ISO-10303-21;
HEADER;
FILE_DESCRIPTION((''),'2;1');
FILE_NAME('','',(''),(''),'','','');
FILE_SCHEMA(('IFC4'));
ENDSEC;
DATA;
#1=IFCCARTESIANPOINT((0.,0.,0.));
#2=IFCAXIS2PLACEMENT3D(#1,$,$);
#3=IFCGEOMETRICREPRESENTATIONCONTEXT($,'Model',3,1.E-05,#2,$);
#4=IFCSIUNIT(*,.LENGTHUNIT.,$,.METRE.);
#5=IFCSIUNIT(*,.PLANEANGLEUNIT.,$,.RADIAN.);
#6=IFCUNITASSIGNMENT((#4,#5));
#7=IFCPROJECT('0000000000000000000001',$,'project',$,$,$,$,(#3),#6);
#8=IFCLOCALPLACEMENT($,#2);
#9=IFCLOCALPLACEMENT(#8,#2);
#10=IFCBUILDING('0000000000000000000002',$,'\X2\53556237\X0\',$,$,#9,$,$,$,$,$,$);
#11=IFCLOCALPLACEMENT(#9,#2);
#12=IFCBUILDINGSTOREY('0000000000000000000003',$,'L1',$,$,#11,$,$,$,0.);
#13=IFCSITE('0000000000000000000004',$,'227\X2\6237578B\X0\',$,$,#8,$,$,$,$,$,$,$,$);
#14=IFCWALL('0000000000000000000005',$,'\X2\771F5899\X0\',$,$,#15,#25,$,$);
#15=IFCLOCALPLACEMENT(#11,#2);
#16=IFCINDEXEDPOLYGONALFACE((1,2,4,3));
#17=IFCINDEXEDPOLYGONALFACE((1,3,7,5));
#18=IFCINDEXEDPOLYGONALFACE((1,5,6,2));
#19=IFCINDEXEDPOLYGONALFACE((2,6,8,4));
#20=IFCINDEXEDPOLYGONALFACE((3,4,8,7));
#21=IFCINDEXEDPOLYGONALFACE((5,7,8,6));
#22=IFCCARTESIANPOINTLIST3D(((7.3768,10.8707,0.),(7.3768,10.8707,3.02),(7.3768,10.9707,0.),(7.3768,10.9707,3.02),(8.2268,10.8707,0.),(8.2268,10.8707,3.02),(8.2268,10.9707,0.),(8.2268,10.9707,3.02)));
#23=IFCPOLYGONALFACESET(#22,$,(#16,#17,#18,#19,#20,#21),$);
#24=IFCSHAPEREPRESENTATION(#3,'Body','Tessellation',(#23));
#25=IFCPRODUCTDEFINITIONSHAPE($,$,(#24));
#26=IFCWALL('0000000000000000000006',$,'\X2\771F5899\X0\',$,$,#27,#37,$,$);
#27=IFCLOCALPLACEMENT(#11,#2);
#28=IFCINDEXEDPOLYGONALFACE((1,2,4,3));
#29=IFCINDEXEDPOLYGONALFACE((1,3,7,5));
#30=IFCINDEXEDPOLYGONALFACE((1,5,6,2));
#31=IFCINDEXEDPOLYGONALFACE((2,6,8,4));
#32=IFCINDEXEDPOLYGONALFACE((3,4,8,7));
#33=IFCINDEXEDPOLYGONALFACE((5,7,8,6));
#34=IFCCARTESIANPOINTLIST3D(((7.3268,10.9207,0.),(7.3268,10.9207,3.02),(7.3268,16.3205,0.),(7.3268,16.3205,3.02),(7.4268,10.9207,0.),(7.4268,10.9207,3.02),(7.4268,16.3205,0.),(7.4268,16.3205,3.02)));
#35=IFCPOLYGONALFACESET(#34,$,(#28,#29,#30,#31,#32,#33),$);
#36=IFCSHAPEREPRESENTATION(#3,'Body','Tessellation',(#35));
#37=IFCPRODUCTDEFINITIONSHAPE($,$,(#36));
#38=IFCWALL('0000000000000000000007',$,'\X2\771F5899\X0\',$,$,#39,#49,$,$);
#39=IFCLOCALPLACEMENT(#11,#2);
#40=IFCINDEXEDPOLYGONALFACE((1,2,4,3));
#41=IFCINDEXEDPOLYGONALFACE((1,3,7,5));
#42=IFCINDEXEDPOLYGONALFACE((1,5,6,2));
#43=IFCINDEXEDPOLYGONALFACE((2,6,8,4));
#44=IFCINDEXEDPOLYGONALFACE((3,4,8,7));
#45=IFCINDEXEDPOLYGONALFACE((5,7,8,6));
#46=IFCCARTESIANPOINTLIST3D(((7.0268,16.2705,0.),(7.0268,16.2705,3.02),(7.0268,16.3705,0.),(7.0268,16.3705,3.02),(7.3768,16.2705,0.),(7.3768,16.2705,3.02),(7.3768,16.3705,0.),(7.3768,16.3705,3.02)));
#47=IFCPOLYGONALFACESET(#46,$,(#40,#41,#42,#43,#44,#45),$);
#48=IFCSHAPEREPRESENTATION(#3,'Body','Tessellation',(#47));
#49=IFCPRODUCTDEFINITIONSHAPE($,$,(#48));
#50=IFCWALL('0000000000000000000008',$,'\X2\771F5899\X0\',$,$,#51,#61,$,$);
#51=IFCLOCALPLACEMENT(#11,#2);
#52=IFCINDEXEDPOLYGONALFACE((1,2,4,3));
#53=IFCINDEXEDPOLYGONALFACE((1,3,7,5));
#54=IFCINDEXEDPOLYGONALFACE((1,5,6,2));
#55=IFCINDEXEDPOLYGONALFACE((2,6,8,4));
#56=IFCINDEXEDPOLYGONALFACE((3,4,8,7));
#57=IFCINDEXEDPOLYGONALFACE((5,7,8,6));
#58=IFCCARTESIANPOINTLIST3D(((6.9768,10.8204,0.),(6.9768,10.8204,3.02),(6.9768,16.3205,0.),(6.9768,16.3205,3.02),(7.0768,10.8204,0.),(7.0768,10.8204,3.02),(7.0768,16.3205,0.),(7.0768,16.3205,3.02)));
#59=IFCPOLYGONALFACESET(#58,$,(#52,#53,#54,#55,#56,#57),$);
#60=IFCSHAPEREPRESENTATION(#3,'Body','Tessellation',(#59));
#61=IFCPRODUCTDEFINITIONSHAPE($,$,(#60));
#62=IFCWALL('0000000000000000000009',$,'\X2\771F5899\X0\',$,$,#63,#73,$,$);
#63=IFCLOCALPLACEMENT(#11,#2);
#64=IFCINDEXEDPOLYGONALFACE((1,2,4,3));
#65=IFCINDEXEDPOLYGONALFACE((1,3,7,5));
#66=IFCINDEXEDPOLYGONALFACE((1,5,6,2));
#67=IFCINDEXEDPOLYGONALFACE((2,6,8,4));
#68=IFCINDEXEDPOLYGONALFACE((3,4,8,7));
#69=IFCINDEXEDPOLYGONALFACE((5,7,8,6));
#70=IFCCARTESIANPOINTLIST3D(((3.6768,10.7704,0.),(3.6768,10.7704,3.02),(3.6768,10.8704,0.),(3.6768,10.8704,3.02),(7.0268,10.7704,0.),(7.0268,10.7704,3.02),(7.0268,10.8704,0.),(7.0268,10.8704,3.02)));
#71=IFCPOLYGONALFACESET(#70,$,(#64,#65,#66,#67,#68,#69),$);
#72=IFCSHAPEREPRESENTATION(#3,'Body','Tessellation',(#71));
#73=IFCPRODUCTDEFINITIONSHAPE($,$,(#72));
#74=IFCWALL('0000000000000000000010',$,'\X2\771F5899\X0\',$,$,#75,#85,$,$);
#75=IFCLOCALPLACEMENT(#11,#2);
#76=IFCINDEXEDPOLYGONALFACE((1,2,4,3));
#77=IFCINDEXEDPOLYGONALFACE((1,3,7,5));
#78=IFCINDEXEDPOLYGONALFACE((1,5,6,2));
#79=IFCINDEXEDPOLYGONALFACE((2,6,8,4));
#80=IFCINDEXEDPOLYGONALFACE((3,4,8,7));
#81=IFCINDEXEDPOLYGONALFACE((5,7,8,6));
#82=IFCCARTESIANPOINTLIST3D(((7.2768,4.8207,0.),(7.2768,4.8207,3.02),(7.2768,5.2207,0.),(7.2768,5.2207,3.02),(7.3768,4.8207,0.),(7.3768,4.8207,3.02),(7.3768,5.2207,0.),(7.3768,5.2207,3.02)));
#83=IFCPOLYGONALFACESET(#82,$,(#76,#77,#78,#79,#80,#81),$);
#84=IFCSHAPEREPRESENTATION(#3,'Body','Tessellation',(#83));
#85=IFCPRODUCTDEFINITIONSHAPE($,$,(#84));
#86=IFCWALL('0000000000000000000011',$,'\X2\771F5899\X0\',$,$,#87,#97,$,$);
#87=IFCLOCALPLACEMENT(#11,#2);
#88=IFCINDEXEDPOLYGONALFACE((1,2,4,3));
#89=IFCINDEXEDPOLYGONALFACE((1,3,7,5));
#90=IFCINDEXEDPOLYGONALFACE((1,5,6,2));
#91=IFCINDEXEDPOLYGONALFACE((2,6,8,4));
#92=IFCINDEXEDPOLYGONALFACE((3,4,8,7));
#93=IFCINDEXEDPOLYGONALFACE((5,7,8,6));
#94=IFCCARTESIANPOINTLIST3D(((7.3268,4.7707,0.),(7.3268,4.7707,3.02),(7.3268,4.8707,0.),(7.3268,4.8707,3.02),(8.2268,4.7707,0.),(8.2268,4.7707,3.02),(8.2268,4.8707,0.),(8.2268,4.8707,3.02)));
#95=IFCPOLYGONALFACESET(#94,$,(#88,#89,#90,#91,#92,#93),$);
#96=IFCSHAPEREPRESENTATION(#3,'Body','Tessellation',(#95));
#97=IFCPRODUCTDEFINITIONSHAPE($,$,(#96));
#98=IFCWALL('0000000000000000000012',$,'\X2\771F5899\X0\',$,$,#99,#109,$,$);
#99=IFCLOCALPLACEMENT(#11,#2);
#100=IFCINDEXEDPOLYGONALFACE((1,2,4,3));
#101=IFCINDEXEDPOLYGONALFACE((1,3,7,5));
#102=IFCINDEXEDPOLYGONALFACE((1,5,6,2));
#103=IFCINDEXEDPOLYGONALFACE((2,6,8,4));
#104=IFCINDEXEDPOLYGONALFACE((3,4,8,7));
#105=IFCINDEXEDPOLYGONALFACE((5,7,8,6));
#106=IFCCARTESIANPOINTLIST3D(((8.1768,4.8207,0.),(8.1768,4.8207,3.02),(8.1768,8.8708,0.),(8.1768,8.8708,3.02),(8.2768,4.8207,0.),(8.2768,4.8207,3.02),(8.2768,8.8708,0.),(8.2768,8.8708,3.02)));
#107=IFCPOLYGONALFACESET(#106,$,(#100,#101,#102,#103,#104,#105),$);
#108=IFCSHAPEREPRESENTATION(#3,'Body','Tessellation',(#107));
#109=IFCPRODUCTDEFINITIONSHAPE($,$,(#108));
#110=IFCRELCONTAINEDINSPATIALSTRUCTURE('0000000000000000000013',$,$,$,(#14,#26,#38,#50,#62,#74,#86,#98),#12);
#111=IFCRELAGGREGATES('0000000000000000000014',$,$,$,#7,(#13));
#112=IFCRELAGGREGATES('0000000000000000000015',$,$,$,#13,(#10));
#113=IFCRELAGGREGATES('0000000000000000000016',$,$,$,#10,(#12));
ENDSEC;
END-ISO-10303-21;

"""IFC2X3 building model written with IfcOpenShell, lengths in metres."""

from ifc_helpers import new_model, si_unit, origin, place, context, project, spatial, polyline, outline, extrude, element, save


model = new_model("IFC2X3")

# Units and contexts
model_context = context("Model", 3, precision=1e-05, world=origin())
ifc_project = project(units=[si_unit("LENGTHUNIT", "METRE"), si_unit("PLANEANGLEUNIT", "RADIAN")], contexts=[model_context])

# Site, building, storey
site_placement = place(None, origin())
site = spatial("IfcSite", under=ifc_project, at=site_placement, Name="227户型")
building_placement = place(site_placement, origin())
building = spatial("IfcBuilding", under=site, at=building_placement, Name="单户")
storey_placement = place(building_placement, origin())
storey = spatial("IfcBuildingStorey", under=building, at=storey_placement, Name="L1", Elevation=0.0)

# Walls
wall_1_placement = place(storey_placement, origin())
element("IfcWall", 1, at=wall_1_placement, inside=storey, Name="真墙", context=model_context, shape_type="SweptSolid", body=[
    extrude(outline(polyline([(8.2268, 10.8707), (7.3768, 10.8707), (7.3768, 10.9707), (8.2268, 10.9707), (8.2268, 10.8707)])), origin(), (0.0, 0.0, 1.0), 3.02),
])
wall_2_placement = place(storey_placement, origin())
element("IfcWall", 2, at=wall_2_placement, inside=storey, Name="真墙", context=model_context, shape_type="SweptSolid", body=[
    extrude(outline(polyline([(7.3268, 10.9207), (7.3268, 16.3205), (7.4268, 16.3205), (7.4268, 10.9207), (7.3268, 10.9207)])), origin(), (0.0, 0.0, 1.0), 3.02),
])
wall_3_placement = place(storey_placement, origin())
element("IfcWall", 3, at=wall_3_placement, inside=storey, Name="真墙", context=model_context, shape_type="SweptSolid", body=[
    extrude(outline(polyline([(7.3768, 16.2705), (7.0268, 16.2705), (7.0268, 16.3705), (7.3768, 16.3705), (7.3768, 16.2705)])), origin(), (0.0, 0.0, 1.0), 3.02),
])
wall_4_placement = place(storey_placement, origin())
element("IfcWall", 4, at=wall_4_placement, inside=storey, Name="真墙", context=model_context, shape_type="SweptSolid", body=[
    extrude(outline(polyline([(7.0768, 16.3205), (7.0768, 10.8204), (6.9768, 10.8204), (6.9768, 16.3205), (7.0768, 16.3205)])), origin(), (0.0, 0.0, 1.0), 3.02),
])
wall_5_placement = place(storey_placement, origin())
element("IfcWall", 5, at=wall_5_placement, inside=storey, Name="真墙", context=model_context, shape_type="SweptSolid", body=[
    extrude(outline(polyline([(7.0268, 10.7704), (3.6768, 10.7704), (3.6768, 10.8704), (7.0268, 10.8704), (7.0268, 10.7704)])), origin(), (0.0, 0.0, 1.0), 3.02),
])
wall_6_placement = place(storey_placement, origin())
element("IfcWall", 6, at=wall_6_placement, inside=storey, Name="真墙", context=model_context, shape_type="SweptSolid", body=[
    extrude(outline(polyline([(7.3768, 5.2207), (7.3768, 4.8207), (7.2768, 4.8207), (7.2768, 5.2207), (7.3768, 5.2207)])), origin(), (0.0, 0.0, 1.0), 3.02),
])
wall_7_placement = place(storey_placement, origin())
element("IfcWall", 7, at=wall_7_placement, inside=storey, Name="真墙", context=model_context, shape_type="SweptSolid", body=[
    extrude(outline(polyline([(7.3268, 4.8707), (8.2268, 4.8707), (8.2268, 4.7707), (7.3268, 4.7707), (7.3268, 4.8707)])), origin(), (0.0, 0.0, 1.0), 3.02),
])
wall_8_placement = place(storey_placement, origin())
element("IfcWall", 8, at=wall_8_placement, inside=storey, Name="真墙", context=model_context, shape_type="SweptSolid", body=[
    extrude(outline(polyline([(8.1768, 4.8207), (8.1768, 8.8708), (8.2768, 8.8708), (8.2768, 4.8207), (8.1768, 4.8207)])), origin(), (0.0, 0.0, 1.0), 3.02),
])

save(model, "model.ifc")
